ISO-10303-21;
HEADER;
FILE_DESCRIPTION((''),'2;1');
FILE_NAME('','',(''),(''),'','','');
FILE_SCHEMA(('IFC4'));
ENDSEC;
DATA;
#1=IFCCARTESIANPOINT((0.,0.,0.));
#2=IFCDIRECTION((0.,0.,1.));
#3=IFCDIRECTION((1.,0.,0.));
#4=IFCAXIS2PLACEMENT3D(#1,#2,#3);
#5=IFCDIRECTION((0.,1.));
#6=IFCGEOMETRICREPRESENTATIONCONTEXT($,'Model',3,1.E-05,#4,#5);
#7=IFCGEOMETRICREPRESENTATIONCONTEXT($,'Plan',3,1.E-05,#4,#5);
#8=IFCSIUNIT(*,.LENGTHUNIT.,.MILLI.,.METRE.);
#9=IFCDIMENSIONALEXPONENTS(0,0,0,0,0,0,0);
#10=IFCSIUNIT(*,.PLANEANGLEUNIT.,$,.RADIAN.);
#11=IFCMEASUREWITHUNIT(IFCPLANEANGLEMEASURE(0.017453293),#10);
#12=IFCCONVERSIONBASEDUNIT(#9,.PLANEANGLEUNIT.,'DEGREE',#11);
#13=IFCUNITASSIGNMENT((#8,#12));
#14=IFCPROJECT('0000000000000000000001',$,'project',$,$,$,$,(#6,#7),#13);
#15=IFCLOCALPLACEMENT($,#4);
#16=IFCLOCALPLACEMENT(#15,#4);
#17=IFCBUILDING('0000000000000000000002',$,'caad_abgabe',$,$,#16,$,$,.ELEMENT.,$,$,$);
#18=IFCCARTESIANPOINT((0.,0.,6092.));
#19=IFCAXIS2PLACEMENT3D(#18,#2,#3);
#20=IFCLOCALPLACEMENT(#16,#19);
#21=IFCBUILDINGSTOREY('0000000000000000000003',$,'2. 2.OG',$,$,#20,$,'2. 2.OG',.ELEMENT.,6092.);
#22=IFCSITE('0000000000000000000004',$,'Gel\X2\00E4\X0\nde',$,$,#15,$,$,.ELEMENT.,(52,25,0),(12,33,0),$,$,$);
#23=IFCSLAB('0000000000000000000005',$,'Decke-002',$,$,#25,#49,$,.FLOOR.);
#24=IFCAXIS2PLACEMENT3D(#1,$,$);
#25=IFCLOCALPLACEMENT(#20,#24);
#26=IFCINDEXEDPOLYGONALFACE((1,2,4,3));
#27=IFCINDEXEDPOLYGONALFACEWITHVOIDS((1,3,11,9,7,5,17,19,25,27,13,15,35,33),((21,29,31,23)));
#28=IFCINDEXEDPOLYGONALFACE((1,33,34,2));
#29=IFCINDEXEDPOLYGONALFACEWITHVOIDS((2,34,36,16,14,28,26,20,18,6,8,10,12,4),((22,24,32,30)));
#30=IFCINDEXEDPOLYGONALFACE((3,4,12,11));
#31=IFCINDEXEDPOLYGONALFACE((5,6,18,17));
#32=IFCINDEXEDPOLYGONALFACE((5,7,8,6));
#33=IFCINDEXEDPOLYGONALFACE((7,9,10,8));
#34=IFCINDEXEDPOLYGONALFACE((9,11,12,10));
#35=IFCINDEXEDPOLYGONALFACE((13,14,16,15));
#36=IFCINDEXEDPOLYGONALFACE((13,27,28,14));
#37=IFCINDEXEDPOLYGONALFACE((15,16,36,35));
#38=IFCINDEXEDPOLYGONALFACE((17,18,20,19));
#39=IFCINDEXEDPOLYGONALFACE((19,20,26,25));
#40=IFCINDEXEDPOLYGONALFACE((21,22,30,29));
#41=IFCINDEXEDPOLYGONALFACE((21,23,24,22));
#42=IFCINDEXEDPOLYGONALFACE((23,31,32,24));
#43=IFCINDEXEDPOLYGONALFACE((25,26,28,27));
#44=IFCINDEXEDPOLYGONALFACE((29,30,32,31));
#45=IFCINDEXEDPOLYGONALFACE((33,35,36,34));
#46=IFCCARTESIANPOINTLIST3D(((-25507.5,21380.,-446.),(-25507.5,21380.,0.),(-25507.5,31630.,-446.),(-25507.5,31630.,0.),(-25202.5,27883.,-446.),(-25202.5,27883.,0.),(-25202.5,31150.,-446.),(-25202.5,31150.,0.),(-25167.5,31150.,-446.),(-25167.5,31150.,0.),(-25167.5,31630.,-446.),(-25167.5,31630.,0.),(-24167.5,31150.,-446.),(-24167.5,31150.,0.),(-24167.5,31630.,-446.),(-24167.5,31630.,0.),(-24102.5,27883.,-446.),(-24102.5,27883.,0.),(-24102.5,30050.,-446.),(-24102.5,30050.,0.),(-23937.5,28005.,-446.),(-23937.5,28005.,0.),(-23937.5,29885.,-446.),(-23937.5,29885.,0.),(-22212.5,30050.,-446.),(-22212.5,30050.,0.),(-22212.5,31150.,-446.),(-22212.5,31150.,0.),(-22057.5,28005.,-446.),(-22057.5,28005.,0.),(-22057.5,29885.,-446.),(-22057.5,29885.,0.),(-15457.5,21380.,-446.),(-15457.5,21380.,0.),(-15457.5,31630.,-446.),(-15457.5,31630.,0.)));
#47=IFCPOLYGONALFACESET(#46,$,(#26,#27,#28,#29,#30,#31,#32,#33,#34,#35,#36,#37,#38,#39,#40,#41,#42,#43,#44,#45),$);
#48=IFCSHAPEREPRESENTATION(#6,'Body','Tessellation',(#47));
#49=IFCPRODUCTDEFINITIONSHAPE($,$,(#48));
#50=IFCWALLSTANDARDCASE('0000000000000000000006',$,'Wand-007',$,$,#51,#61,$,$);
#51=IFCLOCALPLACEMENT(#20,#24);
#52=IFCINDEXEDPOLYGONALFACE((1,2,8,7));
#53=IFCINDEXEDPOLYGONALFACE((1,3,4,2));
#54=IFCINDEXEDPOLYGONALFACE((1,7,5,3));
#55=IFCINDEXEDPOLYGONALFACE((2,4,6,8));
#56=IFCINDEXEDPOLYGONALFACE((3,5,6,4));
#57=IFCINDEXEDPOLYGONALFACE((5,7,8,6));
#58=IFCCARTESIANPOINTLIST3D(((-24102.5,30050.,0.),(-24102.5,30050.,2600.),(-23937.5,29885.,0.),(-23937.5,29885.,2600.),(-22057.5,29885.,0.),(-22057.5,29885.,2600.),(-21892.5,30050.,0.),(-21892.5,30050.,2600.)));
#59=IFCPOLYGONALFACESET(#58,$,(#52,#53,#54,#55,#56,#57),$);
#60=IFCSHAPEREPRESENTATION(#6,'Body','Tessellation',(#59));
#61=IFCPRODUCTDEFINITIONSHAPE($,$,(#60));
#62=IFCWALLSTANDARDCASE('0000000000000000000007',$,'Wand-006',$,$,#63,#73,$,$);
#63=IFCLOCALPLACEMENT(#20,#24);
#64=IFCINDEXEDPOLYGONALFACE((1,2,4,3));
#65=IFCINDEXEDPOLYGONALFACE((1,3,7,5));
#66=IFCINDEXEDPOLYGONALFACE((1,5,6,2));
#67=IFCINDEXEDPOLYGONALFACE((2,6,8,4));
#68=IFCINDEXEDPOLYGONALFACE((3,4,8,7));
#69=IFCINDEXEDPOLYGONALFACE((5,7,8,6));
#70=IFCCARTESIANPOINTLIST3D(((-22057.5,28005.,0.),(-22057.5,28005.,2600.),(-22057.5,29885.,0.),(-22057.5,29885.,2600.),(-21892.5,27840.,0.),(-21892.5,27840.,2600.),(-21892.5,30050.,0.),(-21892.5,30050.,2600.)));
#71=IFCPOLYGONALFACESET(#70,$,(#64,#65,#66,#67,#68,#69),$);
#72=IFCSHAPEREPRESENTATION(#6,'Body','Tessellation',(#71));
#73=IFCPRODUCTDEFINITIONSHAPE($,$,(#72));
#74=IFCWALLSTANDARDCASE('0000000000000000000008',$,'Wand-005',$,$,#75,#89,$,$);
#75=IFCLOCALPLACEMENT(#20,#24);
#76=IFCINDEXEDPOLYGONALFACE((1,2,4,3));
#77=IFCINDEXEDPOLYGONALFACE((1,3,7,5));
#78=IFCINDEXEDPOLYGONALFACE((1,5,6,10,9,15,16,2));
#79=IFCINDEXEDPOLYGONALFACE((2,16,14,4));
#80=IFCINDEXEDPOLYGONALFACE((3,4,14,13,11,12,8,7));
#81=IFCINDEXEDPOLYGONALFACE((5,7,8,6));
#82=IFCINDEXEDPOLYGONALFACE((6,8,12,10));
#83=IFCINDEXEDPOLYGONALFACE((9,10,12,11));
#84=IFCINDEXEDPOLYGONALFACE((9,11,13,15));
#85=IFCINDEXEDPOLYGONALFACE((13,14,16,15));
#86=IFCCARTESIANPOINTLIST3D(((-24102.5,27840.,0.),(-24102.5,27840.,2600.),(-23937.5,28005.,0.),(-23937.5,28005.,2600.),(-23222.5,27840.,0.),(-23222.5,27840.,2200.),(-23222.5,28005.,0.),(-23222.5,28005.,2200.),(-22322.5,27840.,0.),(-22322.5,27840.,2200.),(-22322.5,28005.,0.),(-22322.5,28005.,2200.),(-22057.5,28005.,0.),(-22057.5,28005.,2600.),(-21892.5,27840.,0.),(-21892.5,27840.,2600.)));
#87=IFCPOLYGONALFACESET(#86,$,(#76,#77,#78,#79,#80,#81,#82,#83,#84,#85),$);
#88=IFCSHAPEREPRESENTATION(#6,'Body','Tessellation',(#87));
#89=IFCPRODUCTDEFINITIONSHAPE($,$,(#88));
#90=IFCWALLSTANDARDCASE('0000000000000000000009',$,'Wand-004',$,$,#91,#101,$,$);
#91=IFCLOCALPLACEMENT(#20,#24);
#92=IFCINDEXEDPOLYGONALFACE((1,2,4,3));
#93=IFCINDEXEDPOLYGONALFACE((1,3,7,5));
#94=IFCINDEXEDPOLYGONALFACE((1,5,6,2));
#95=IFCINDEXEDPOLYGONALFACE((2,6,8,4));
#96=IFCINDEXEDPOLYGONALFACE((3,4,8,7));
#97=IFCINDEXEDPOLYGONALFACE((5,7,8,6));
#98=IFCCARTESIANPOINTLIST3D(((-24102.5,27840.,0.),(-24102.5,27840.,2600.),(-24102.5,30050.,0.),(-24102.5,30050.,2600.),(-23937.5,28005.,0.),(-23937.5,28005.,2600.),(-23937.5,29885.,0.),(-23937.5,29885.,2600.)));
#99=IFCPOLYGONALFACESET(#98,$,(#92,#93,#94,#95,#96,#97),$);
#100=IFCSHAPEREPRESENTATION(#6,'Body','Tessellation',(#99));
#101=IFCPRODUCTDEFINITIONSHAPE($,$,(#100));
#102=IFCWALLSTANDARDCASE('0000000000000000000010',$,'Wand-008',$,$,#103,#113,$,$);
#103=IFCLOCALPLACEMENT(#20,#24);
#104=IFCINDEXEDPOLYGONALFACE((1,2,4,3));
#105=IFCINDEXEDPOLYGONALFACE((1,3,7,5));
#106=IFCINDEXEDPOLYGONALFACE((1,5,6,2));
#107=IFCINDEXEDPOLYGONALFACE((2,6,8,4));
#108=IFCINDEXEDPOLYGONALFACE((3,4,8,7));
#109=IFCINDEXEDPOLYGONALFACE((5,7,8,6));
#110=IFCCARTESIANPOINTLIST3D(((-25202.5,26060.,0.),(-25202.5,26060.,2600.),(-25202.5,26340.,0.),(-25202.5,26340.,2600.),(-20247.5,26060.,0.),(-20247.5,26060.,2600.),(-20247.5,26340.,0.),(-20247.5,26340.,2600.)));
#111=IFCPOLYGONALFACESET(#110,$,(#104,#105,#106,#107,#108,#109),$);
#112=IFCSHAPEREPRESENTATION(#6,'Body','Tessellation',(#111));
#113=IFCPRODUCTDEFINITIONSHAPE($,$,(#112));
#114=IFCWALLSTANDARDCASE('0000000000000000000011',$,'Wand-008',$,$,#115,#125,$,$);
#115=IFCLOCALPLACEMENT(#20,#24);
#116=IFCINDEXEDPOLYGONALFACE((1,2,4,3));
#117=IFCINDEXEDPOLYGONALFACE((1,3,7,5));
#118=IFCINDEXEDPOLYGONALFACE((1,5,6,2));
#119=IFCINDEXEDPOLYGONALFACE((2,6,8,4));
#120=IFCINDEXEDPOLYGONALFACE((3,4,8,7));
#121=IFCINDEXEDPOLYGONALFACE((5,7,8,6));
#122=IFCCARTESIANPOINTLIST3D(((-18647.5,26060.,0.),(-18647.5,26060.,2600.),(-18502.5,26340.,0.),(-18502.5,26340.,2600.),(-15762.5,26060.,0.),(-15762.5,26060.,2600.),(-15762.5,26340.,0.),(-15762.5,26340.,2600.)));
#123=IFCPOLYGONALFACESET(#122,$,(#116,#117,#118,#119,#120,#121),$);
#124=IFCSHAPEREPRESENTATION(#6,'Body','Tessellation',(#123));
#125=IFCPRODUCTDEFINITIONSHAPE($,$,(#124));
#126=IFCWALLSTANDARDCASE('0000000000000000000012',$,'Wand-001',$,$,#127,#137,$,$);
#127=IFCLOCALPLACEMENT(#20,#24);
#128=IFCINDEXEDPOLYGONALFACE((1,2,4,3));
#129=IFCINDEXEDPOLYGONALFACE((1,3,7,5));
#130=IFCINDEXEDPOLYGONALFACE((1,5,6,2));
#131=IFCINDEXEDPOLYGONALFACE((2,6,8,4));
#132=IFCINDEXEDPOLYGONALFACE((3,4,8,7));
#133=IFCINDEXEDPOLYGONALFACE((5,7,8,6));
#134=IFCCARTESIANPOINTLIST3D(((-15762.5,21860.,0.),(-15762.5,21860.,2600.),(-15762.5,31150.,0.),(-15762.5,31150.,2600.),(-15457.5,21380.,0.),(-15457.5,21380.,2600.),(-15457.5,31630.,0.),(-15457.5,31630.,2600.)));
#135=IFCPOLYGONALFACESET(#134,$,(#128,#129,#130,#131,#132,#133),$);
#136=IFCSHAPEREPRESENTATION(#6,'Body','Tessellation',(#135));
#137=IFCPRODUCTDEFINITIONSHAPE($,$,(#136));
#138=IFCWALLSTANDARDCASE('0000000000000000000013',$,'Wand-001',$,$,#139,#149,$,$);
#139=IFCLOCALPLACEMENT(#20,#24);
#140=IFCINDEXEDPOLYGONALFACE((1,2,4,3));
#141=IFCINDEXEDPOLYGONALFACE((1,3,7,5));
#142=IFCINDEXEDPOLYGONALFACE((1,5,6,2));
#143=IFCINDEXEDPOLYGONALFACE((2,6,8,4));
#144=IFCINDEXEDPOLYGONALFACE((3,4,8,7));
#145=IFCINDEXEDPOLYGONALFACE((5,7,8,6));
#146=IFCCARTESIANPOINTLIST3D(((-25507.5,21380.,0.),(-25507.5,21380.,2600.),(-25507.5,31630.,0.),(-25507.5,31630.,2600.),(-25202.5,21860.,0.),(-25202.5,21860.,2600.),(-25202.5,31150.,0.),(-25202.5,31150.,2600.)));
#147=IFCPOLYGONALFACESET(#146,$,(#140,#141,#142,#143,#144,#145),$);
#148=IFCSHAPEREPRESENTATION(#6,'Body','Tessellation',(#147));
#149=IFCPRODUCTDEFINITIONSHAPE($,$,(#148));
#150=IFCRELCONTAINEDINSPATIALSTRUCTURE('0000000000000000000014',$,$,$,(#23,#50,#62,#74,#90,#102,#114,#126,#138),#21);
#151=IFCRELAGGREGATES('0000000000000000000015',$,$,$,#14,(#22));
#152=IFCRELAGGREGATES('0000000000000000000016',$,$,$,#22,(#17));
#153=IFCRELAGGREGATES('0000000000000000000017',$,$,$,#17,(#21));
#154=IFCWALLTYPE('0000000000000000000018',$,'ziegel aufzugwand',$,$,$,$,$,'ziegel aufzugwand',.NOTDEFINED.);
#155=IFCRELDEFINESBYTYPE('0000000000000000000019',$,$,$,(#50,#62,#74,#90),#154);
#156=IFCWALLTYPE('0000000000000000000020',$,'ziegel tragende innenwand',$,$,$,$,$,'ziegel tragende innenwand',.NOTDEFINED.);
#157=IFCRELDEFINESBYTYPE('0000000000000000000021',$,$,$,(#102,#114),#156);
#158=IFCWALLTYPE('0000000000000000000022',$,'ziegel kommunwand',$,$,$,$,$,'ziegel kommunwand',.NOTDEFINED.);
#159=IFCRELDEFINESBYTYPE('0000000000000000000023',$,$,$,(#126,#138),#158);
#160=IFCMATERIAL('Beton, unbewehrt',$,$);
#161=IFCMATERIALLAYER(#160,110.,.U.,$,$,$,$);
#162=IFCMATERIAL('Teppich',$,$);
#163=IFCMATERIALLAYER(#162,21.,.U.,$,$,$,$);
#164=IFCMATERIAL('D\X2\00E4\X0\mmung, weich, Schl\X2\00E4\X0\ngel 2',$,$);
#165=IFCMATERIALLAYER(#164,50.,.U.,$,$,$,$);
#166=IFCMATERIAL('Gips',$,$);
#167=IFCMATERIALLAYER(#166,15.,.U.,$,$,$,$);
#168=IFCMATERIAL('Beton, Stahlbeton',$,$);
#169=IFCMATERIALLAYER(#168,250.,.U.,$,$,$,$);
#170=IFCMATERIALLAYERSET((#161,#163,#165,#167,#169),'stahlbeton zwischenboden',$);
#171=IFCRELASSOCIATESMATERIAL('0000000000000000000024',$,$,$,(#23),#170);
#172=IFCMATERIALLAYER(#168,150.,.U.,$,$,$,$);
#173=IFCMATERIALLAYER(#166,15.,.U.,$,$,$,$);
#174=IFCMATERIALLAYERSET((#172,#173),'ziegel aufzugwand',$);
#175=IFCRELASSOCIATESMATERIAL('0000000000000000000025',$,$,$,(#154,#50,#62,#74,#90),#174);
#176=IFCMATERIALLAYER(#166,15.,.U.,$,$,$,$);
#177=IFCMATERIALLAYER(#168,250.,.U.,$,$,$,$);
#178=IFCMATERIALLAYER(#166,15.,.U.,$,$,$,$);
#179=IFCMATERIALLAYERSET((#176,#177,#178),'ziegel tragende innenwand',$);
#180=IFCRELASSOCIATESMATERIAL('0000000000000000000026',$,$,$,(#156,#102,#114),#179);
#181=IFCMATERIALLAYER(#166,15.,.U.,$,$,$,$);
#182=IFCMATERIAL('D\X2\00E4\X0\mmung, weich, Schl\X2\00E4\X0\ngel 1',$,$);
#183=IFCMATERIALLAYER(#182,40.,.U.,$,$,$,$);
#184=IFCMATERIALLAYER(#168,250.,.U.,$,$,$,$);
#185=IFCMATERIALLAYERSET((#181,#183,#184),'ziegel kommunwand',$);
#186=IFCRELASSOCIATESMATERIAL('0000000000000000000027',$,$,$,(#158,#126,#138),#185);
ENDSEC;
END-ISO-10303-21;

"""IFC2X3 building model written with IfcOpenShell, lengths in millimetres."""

from ifc_helpers import new_model, entity, si_unit, converted_unit, direction, frame, frame_2d, origin_with_axes, place, context, project, spatial, polyline, rectangle, outline, extrude, material, layer, layer_set, layer_usage, type_object, element, save


model = new_model("IFC2X3")

# Units and contexts
model_context = context("Model", 3, precision=1e-05, world=origin_with_axes(), true_north=direction((0.0, 1.0)))
plan_context = context("Plan", 3, precision=1e-05, world=origin_with_axes(), true_north=direction((0.0, 1.0)))
ifc_project = project(units=[si_unit("LENGTHUNIT", "METRE", prefix="MILLI"), converted_unit("PLANEANGLEUNIT", "DEGREE", entity("IfcPlaneAngleMeasure", 0.017453293), si_unit("PLANEANGLEUNIT", "RADIAN"), dimensions=[0, 0, 0, 0, 0, 0, 0])], contexts=[model_context, plan_context])

# Site, building, storey
site_placement = place(None, origin_with_axes())
site = spatial("IfcSite", under=ifc_project, at=site_placement, Name="Gelände", CompositionType="ELEMENT", RefLatitude=(52, 25, 0), RefLongitude=(12, 33, 0))
building_placement = place(site_placement, origin_with_axes())
building = spatial("IfcBuilding", under=site, at=building_placement, Name="caad_abgabe", CompositionType="ELEMENT")
storey_placement = place(building_placement, frame((0.0, 0.0, 6092.0), z_axis=(0.0, 0.0, 1.0), x_axis=(1.0, 0.0, 0.0)))
storey = spatial("IfcBuildingStorey", under=building, at=storey_placement, Name="2. 2.OG", LongName="2. 2.OG", CompositionType="ELEMENT", Elevation=6092.0)

# Slab, opening
ifc_material_1 = material(Name="Beton, unbewehrt")
ifc_layer_1 = layer(ifc_material_1, 110.0, ventilated="UNKNOWN")
ifc_material_2 = material(Name="Teppich")
ifc_layer_2 = layer(ifc_material_2, 21.0, ventilated="UNKNOWN")
ifc_material_3 = material(Name="Dämmung, weich, Schlängel 2")
ifc_layer_3 = layer(ifc_material_3, 50.0, ventilated="UNKNOWN")
ifc_material_4 = material(Name="Gips")
ifc_layer_4 = layer(ifc_material_4, 15.0, ventilated="UNKNOWN")
ifc_material_5 = material(Name="Beton, Stahlbeton")
ifc_layer_5 = layer(ifc_material_5, 250.0, ventilated="UNKNOWN")
ifc_layer_set_1 = layer_set([ifc_layer_1, ifc_layer_2, ifc_layer_3, ifc_layer_4, ifc_layer_5], Name="stahlbeton zwischenboden")
ifc_layer_usage_1 = layer_usage(ifc_layer_set_1, "AXIS3", "NEGATIVE", 446.0)
slab_placement = place(storey_placement, frame((-25507.5, 31630.0, -446.0), z_axis=(0.0, 0.0, 1.0), x_axis=(0.0, -1.0, 0.0)))
slab = element("IfcSlab", 1, at=slab_placement, inside=storey, material=ifc_layer_usage_1, Name="Decke-002", PredefinedType="FLOOR", context=model_context, shape_type="SweptSolid", body=[
    extrude(outline(polyline([(0.0, 0.0), (10250.0, 0.0), (10250.0, 10050.0), (0.0, 10050.0), (0.0, 1340.0), (480.0, 1340.0), (480.0, 3295.0), (1580.0, 3295.0), (1580.0, 1405.0), (3747.0, 1405.0), (3747.0, 305.0), (480.0, 305.0), (480.0, 340.0), (0.0, 340.0), (0.0, 0.0)])), origin_with_axes(), (0.0, 0.0, 1.0), 446.0),
])
opening_1_placement = place(slab_placement, origin_with_axes())
element("IfcOpeningElement", 2, at=opening_1_placement, cuts=slab, context=model_context, shape_type="SweptSolid", body=[
    extrude(outline(polyline([(3625.0, 1570.0), (1745.0, 1570.0), (1745.0, 3450.0), (3625.0, 3450.0), (3625.0, 1570.0)])), origin_with_axes(), (0.0, 0.0, 1.0), 446.0),
])

# Walls
ifc_layer_6 = layer(ifc_material_5, 150.0, ventilated="UNKNOWN")
ifc_layer_7 = layer(ifc_material_4, 15.0, ventilated="UNKNOWN")
ifc_layer_set_2 = layer_set([ifc_layer_6, ifc_layer_7], Name="ziegel aufzugwand")
ifc_layer_usage_2 = layer_usage(ifc_layer_set_2, "AXIS2", "POSITIVE", 0.0)
wall_type_1 = type_object("IfcWallType", Name="ziegel aufzugwand", ElementType="ziegel aufzugwand", PredefinedType="NOTDEFINED", material=ifc_layer_set_2)
wall_1_placement = place(storey_placement, frame((-21892.5, 30050.0, 0.0), z_axis=(0.0, 0.0, 1.0), x_axis=(-1.0, 0.0, 0.0)))
element("IfcWallStandardCase", 3, at=wall_1_placement, inside=storey, type_object=wall_type_1, material=ifc_layer_usage_2, Name="Wand-007", context=model_context, shape_type="SweptSolid", body=[
    extrude(outline(polyline([(0.0, 0.0), (2210.0, 0.0), (2045.0, 165.0), (165.0, 165.0), (0.0, 0.0)])), origin_with_axes(), (0.0, 0.0, 1.0), 2600.0),
])
ifc_layer_usage_3 = layer_usage(ifc_layer_set_2, "AXIS2", "POSITIVE", 0.0)
wall_2_placement = place(storey_placement, frame((-21892.5, 27840.0, 0.0), z_axis=(0.0, 0.0, 1.0), x_axis=(0.0, 1.0, 0.0)))
element("IfcWallStandardCase", 4, at=wall_2_placement, inside=storey, type_object=wall_type_1, material=ifc_layer_usage_3, Name="Wand-006", context=model_context, shape_type="SweptSolid", body=[
    extrude(outline(polyline([(0.0, 0.0), (2210.0, 0.0), (2045.0, 165.0), (165.0, 165.0), (0.0, 0.0)])), origin_with_axes(), (0.0, 0.0, 1.0), 2600.0),
])

# Wall, opening
ifc_layer_usage_4 = layer_usage(ifc_layer_set_2, "AXIS2", "POSITIVE", 0.0)
wall_3_placement = place(storey_placement, frame((-24102.5, 27840.0, 0.0), z_axis=(0.0, 0.0, 1.0), x_axis=(1.0, 0.0, 0.0)))
wall_3 = element("IfcWallStandardCase", 5, at=wall_3_placement, inside=storey, type_object=wall_type_1, material=ifc_layer_usage_4, Name="Wand-005", context=model_context, shape_type="SweptSolid", body=[
    extrude(outline(polyline([(0.0, 0.0), (2210.0, 0.0), (2045.0, 165.0), (165.0, 165.0), (0.0, 0.0)])), origin_with_axes(), (0.0, 0.0, 1.0), 2600.0),
])
opening_2_placement = place(wall_3_placement, frame((1330.0, 0.0, 0.0), z_axis=(0.0, 0.0, 1.0), x_axis=(1.0, 0.0, 0.0)))
element("IfcOpeningElement", 6, at=opening_2_placement, cuts=wall_3, ObjectType="Opening", context=model_context, shape_type="SweptSolid", body=[
    extrude(rectangle(XDim=900.0, YDim=2200.0, at=frame_2d((0.0, 1100.0), x_axis=(-1.0, 0.0))), frame((0.0, 0.0, 0.0), z_axis=(0.0, 1.0, 0.0), x_axis=(-1.0, 0.0, 0.0)), (0.0, 0.0, 1.0), 165.0),
])

# Walls
ifc_layer_usage_5 = layer_usage(ifc_layer_set_2, "AXIS2", "POSITIVE", 0.0)
wall_4_placement = place(storey_placement, frame((-24102.5, 30050.0, 0.0), z_axis=(0.0, 0.0, 1.0), x_axis=(0.0, -1.0, 0.0)))
element("IfcWallStandardCase", 7, at=wall_4_placement, inside=storey, type_object=wall_type_1, material=ifc_layer_usage_5, Name="Wand-004", context=model_context, shape_type="SweptSolid", body=[
    extrude(outline(polyline([(0.0, 0.0), (2210.0, 0.0), (2045.0, 165.0), (165.0, 165.0), (0.0, 0.0)])), origin_with_axes(), (0.0, 0.0, 1.0), 2600.0),
])
ifc_layer_8 = layer(ifc_material_4, 15.0, ventilated="UNKNOWN")
ifc_layer_9 = layer(ifc_material_5, 250.0, ventilated="UNKNOWN")
ifc_layer_10 = layer(ifc_material_4, 15.0, ventilated="UNKNOWN")
ifc_layer_set_3 = layer_set([ifc_layer_8, ifc_layer_9, ifc_layer_10], Name="ziegel tragende innenwand")
ifc_layer_usage_6 = layer_usage(ifc_layer_set_3, "AXIS2", "NEGATIVE", 0.0)
wall_type_2 = type_object("IfcWallType", Name="ziegel tragende innenwand", ElementType="ziegel tragende innenwand", PredefinedType="NOTDEFINED", material=ifc_layer_set_3)
wall_5_placement = place(storey_placement, frame((-25202.5, 26340.0, 0.0), z_axis=(0.0, 0.0, 1.0), x_axis=(1.0, 0.0, 0.0)))
element("IfcWallStandardCase", 8, at=wall_5_placement, inside=storey, type_object=wall_type_2, material=ifc_layer_usage_6, Name="Wand-008", context=model_context, shape_type="SweptSolid", body=[
    extrude(outline(polyline([(0.0, -280.0), (4955.0, -280.0), (4955.0, 0.0), (0.0, 0.0), (0.0, -280.0)])), origin_with_axes(), (0.0, 0.0, 1.0), 2600.0),
])
ifc_layer_usage_7 = layer_usage(ifc_layer_set_3, "AXIS2", "NEGATIVE", 0.0)
wall_6_placement = place(storey_placement, frame((-18647.5, 26340.0, 0.0), z_axis=(0.0, 0.0, 1.0), x_axis=(1.0, 0.0, 0.0)))
element("IfcWallStandardCase", 9, at=wall_6_placement, inside=storey, type_object=wall_type_2, material=ifc_layer_usage_7, Name="Wand-008", context=model_context, shape_type="SweptSolid", body=[
    extrude(outline(polyline([(0.0, -280.0), (2885.0, -280.0), (2885.0, 0.0), (145.0, 0.0), (0.0, -280.0)])), origin_with_axes(), (0.0, 0.0, 1.0), 2600.0),
])
ifc_layer_11 = layer(ifc_material_4, 15.0, ventilated="UNKNOWN")
ifc_material_6 = material(Name="Dämmung, weich, Schlängel 1")
ifc_layer_12 = layer(ifc_material_6, 40.0, ventilated="UNKNOWN")
ifc_layer_13 = layer(ifc_material_5, 250.0, ventilated="UNKNOWN")
ifc_layer_set_4 = layer_set([ifc_layer_11, ifc_layer_12, ifc_layer_13], Name="ziegel kommunwand")
ifc_layer_usage_8 = layer_usage(ifc_layer_set_4, "AXIS2", "NEGATIVE", 0.0)
wall_type_3 = type_object("IfcWallType", Name="ziegel kommunwand", ElementType="ziegel kommunwand", PredefinedType="NOTDEFINED", material=ifc_layer_set_4)
wall_7_placement = place(storey_placement, frame((-15457.5, 31630.0, 0.0), z_axis=(0.0, 0.0, 1.0), x_axis=(0.0, -1.0, 0.0)))
element("IfcWallStandardCase", 10, at=wall_7_placement, inside=storey, type_object=wall_type_3, material=ifc_layer_usage_8, Name="Wand-001", context=model_context, shape_type="SweptSolid", body=[
    extrude(outline(polyline([(480.0, -305.0), (9770.0, -305.0), (10250.0, 0.0), (0.0, 0.0), (480.0, -305.0)])), origin_with_axes(), (0.0, 0.0, 1.0), 2600.0),
])
ifc_layer_usage_9 = layer_usage(ifc_layer_set_4, "AXIS2", "POSITIVE", 0.0)
wall_8_placement = place(storey_placement, frame((-25507.5, 31630.0, 0.0), z_axis=(0.0, 0.0, 1.0), x_axis=(0.0, -1.0, 0.0)))
element("IfcWallStandardCase", 11, at=wall_8_placement, inside=storey, type_object=wall_type_3, material=ifc_layer_usage_9, Name="Wand-001", context=model_context, shape_type="SweptSolid", body=[
    extrude(outline(polyline([(0.0, 0.0), (10250.0, 0.0), (9770.0, 305.0), (480.0, 305.0), (0.0, 0.0)])), origin_with_axes(), (0.0, 0.0, 1.0), 2600.0),
])

save(model, "model.ifc")
